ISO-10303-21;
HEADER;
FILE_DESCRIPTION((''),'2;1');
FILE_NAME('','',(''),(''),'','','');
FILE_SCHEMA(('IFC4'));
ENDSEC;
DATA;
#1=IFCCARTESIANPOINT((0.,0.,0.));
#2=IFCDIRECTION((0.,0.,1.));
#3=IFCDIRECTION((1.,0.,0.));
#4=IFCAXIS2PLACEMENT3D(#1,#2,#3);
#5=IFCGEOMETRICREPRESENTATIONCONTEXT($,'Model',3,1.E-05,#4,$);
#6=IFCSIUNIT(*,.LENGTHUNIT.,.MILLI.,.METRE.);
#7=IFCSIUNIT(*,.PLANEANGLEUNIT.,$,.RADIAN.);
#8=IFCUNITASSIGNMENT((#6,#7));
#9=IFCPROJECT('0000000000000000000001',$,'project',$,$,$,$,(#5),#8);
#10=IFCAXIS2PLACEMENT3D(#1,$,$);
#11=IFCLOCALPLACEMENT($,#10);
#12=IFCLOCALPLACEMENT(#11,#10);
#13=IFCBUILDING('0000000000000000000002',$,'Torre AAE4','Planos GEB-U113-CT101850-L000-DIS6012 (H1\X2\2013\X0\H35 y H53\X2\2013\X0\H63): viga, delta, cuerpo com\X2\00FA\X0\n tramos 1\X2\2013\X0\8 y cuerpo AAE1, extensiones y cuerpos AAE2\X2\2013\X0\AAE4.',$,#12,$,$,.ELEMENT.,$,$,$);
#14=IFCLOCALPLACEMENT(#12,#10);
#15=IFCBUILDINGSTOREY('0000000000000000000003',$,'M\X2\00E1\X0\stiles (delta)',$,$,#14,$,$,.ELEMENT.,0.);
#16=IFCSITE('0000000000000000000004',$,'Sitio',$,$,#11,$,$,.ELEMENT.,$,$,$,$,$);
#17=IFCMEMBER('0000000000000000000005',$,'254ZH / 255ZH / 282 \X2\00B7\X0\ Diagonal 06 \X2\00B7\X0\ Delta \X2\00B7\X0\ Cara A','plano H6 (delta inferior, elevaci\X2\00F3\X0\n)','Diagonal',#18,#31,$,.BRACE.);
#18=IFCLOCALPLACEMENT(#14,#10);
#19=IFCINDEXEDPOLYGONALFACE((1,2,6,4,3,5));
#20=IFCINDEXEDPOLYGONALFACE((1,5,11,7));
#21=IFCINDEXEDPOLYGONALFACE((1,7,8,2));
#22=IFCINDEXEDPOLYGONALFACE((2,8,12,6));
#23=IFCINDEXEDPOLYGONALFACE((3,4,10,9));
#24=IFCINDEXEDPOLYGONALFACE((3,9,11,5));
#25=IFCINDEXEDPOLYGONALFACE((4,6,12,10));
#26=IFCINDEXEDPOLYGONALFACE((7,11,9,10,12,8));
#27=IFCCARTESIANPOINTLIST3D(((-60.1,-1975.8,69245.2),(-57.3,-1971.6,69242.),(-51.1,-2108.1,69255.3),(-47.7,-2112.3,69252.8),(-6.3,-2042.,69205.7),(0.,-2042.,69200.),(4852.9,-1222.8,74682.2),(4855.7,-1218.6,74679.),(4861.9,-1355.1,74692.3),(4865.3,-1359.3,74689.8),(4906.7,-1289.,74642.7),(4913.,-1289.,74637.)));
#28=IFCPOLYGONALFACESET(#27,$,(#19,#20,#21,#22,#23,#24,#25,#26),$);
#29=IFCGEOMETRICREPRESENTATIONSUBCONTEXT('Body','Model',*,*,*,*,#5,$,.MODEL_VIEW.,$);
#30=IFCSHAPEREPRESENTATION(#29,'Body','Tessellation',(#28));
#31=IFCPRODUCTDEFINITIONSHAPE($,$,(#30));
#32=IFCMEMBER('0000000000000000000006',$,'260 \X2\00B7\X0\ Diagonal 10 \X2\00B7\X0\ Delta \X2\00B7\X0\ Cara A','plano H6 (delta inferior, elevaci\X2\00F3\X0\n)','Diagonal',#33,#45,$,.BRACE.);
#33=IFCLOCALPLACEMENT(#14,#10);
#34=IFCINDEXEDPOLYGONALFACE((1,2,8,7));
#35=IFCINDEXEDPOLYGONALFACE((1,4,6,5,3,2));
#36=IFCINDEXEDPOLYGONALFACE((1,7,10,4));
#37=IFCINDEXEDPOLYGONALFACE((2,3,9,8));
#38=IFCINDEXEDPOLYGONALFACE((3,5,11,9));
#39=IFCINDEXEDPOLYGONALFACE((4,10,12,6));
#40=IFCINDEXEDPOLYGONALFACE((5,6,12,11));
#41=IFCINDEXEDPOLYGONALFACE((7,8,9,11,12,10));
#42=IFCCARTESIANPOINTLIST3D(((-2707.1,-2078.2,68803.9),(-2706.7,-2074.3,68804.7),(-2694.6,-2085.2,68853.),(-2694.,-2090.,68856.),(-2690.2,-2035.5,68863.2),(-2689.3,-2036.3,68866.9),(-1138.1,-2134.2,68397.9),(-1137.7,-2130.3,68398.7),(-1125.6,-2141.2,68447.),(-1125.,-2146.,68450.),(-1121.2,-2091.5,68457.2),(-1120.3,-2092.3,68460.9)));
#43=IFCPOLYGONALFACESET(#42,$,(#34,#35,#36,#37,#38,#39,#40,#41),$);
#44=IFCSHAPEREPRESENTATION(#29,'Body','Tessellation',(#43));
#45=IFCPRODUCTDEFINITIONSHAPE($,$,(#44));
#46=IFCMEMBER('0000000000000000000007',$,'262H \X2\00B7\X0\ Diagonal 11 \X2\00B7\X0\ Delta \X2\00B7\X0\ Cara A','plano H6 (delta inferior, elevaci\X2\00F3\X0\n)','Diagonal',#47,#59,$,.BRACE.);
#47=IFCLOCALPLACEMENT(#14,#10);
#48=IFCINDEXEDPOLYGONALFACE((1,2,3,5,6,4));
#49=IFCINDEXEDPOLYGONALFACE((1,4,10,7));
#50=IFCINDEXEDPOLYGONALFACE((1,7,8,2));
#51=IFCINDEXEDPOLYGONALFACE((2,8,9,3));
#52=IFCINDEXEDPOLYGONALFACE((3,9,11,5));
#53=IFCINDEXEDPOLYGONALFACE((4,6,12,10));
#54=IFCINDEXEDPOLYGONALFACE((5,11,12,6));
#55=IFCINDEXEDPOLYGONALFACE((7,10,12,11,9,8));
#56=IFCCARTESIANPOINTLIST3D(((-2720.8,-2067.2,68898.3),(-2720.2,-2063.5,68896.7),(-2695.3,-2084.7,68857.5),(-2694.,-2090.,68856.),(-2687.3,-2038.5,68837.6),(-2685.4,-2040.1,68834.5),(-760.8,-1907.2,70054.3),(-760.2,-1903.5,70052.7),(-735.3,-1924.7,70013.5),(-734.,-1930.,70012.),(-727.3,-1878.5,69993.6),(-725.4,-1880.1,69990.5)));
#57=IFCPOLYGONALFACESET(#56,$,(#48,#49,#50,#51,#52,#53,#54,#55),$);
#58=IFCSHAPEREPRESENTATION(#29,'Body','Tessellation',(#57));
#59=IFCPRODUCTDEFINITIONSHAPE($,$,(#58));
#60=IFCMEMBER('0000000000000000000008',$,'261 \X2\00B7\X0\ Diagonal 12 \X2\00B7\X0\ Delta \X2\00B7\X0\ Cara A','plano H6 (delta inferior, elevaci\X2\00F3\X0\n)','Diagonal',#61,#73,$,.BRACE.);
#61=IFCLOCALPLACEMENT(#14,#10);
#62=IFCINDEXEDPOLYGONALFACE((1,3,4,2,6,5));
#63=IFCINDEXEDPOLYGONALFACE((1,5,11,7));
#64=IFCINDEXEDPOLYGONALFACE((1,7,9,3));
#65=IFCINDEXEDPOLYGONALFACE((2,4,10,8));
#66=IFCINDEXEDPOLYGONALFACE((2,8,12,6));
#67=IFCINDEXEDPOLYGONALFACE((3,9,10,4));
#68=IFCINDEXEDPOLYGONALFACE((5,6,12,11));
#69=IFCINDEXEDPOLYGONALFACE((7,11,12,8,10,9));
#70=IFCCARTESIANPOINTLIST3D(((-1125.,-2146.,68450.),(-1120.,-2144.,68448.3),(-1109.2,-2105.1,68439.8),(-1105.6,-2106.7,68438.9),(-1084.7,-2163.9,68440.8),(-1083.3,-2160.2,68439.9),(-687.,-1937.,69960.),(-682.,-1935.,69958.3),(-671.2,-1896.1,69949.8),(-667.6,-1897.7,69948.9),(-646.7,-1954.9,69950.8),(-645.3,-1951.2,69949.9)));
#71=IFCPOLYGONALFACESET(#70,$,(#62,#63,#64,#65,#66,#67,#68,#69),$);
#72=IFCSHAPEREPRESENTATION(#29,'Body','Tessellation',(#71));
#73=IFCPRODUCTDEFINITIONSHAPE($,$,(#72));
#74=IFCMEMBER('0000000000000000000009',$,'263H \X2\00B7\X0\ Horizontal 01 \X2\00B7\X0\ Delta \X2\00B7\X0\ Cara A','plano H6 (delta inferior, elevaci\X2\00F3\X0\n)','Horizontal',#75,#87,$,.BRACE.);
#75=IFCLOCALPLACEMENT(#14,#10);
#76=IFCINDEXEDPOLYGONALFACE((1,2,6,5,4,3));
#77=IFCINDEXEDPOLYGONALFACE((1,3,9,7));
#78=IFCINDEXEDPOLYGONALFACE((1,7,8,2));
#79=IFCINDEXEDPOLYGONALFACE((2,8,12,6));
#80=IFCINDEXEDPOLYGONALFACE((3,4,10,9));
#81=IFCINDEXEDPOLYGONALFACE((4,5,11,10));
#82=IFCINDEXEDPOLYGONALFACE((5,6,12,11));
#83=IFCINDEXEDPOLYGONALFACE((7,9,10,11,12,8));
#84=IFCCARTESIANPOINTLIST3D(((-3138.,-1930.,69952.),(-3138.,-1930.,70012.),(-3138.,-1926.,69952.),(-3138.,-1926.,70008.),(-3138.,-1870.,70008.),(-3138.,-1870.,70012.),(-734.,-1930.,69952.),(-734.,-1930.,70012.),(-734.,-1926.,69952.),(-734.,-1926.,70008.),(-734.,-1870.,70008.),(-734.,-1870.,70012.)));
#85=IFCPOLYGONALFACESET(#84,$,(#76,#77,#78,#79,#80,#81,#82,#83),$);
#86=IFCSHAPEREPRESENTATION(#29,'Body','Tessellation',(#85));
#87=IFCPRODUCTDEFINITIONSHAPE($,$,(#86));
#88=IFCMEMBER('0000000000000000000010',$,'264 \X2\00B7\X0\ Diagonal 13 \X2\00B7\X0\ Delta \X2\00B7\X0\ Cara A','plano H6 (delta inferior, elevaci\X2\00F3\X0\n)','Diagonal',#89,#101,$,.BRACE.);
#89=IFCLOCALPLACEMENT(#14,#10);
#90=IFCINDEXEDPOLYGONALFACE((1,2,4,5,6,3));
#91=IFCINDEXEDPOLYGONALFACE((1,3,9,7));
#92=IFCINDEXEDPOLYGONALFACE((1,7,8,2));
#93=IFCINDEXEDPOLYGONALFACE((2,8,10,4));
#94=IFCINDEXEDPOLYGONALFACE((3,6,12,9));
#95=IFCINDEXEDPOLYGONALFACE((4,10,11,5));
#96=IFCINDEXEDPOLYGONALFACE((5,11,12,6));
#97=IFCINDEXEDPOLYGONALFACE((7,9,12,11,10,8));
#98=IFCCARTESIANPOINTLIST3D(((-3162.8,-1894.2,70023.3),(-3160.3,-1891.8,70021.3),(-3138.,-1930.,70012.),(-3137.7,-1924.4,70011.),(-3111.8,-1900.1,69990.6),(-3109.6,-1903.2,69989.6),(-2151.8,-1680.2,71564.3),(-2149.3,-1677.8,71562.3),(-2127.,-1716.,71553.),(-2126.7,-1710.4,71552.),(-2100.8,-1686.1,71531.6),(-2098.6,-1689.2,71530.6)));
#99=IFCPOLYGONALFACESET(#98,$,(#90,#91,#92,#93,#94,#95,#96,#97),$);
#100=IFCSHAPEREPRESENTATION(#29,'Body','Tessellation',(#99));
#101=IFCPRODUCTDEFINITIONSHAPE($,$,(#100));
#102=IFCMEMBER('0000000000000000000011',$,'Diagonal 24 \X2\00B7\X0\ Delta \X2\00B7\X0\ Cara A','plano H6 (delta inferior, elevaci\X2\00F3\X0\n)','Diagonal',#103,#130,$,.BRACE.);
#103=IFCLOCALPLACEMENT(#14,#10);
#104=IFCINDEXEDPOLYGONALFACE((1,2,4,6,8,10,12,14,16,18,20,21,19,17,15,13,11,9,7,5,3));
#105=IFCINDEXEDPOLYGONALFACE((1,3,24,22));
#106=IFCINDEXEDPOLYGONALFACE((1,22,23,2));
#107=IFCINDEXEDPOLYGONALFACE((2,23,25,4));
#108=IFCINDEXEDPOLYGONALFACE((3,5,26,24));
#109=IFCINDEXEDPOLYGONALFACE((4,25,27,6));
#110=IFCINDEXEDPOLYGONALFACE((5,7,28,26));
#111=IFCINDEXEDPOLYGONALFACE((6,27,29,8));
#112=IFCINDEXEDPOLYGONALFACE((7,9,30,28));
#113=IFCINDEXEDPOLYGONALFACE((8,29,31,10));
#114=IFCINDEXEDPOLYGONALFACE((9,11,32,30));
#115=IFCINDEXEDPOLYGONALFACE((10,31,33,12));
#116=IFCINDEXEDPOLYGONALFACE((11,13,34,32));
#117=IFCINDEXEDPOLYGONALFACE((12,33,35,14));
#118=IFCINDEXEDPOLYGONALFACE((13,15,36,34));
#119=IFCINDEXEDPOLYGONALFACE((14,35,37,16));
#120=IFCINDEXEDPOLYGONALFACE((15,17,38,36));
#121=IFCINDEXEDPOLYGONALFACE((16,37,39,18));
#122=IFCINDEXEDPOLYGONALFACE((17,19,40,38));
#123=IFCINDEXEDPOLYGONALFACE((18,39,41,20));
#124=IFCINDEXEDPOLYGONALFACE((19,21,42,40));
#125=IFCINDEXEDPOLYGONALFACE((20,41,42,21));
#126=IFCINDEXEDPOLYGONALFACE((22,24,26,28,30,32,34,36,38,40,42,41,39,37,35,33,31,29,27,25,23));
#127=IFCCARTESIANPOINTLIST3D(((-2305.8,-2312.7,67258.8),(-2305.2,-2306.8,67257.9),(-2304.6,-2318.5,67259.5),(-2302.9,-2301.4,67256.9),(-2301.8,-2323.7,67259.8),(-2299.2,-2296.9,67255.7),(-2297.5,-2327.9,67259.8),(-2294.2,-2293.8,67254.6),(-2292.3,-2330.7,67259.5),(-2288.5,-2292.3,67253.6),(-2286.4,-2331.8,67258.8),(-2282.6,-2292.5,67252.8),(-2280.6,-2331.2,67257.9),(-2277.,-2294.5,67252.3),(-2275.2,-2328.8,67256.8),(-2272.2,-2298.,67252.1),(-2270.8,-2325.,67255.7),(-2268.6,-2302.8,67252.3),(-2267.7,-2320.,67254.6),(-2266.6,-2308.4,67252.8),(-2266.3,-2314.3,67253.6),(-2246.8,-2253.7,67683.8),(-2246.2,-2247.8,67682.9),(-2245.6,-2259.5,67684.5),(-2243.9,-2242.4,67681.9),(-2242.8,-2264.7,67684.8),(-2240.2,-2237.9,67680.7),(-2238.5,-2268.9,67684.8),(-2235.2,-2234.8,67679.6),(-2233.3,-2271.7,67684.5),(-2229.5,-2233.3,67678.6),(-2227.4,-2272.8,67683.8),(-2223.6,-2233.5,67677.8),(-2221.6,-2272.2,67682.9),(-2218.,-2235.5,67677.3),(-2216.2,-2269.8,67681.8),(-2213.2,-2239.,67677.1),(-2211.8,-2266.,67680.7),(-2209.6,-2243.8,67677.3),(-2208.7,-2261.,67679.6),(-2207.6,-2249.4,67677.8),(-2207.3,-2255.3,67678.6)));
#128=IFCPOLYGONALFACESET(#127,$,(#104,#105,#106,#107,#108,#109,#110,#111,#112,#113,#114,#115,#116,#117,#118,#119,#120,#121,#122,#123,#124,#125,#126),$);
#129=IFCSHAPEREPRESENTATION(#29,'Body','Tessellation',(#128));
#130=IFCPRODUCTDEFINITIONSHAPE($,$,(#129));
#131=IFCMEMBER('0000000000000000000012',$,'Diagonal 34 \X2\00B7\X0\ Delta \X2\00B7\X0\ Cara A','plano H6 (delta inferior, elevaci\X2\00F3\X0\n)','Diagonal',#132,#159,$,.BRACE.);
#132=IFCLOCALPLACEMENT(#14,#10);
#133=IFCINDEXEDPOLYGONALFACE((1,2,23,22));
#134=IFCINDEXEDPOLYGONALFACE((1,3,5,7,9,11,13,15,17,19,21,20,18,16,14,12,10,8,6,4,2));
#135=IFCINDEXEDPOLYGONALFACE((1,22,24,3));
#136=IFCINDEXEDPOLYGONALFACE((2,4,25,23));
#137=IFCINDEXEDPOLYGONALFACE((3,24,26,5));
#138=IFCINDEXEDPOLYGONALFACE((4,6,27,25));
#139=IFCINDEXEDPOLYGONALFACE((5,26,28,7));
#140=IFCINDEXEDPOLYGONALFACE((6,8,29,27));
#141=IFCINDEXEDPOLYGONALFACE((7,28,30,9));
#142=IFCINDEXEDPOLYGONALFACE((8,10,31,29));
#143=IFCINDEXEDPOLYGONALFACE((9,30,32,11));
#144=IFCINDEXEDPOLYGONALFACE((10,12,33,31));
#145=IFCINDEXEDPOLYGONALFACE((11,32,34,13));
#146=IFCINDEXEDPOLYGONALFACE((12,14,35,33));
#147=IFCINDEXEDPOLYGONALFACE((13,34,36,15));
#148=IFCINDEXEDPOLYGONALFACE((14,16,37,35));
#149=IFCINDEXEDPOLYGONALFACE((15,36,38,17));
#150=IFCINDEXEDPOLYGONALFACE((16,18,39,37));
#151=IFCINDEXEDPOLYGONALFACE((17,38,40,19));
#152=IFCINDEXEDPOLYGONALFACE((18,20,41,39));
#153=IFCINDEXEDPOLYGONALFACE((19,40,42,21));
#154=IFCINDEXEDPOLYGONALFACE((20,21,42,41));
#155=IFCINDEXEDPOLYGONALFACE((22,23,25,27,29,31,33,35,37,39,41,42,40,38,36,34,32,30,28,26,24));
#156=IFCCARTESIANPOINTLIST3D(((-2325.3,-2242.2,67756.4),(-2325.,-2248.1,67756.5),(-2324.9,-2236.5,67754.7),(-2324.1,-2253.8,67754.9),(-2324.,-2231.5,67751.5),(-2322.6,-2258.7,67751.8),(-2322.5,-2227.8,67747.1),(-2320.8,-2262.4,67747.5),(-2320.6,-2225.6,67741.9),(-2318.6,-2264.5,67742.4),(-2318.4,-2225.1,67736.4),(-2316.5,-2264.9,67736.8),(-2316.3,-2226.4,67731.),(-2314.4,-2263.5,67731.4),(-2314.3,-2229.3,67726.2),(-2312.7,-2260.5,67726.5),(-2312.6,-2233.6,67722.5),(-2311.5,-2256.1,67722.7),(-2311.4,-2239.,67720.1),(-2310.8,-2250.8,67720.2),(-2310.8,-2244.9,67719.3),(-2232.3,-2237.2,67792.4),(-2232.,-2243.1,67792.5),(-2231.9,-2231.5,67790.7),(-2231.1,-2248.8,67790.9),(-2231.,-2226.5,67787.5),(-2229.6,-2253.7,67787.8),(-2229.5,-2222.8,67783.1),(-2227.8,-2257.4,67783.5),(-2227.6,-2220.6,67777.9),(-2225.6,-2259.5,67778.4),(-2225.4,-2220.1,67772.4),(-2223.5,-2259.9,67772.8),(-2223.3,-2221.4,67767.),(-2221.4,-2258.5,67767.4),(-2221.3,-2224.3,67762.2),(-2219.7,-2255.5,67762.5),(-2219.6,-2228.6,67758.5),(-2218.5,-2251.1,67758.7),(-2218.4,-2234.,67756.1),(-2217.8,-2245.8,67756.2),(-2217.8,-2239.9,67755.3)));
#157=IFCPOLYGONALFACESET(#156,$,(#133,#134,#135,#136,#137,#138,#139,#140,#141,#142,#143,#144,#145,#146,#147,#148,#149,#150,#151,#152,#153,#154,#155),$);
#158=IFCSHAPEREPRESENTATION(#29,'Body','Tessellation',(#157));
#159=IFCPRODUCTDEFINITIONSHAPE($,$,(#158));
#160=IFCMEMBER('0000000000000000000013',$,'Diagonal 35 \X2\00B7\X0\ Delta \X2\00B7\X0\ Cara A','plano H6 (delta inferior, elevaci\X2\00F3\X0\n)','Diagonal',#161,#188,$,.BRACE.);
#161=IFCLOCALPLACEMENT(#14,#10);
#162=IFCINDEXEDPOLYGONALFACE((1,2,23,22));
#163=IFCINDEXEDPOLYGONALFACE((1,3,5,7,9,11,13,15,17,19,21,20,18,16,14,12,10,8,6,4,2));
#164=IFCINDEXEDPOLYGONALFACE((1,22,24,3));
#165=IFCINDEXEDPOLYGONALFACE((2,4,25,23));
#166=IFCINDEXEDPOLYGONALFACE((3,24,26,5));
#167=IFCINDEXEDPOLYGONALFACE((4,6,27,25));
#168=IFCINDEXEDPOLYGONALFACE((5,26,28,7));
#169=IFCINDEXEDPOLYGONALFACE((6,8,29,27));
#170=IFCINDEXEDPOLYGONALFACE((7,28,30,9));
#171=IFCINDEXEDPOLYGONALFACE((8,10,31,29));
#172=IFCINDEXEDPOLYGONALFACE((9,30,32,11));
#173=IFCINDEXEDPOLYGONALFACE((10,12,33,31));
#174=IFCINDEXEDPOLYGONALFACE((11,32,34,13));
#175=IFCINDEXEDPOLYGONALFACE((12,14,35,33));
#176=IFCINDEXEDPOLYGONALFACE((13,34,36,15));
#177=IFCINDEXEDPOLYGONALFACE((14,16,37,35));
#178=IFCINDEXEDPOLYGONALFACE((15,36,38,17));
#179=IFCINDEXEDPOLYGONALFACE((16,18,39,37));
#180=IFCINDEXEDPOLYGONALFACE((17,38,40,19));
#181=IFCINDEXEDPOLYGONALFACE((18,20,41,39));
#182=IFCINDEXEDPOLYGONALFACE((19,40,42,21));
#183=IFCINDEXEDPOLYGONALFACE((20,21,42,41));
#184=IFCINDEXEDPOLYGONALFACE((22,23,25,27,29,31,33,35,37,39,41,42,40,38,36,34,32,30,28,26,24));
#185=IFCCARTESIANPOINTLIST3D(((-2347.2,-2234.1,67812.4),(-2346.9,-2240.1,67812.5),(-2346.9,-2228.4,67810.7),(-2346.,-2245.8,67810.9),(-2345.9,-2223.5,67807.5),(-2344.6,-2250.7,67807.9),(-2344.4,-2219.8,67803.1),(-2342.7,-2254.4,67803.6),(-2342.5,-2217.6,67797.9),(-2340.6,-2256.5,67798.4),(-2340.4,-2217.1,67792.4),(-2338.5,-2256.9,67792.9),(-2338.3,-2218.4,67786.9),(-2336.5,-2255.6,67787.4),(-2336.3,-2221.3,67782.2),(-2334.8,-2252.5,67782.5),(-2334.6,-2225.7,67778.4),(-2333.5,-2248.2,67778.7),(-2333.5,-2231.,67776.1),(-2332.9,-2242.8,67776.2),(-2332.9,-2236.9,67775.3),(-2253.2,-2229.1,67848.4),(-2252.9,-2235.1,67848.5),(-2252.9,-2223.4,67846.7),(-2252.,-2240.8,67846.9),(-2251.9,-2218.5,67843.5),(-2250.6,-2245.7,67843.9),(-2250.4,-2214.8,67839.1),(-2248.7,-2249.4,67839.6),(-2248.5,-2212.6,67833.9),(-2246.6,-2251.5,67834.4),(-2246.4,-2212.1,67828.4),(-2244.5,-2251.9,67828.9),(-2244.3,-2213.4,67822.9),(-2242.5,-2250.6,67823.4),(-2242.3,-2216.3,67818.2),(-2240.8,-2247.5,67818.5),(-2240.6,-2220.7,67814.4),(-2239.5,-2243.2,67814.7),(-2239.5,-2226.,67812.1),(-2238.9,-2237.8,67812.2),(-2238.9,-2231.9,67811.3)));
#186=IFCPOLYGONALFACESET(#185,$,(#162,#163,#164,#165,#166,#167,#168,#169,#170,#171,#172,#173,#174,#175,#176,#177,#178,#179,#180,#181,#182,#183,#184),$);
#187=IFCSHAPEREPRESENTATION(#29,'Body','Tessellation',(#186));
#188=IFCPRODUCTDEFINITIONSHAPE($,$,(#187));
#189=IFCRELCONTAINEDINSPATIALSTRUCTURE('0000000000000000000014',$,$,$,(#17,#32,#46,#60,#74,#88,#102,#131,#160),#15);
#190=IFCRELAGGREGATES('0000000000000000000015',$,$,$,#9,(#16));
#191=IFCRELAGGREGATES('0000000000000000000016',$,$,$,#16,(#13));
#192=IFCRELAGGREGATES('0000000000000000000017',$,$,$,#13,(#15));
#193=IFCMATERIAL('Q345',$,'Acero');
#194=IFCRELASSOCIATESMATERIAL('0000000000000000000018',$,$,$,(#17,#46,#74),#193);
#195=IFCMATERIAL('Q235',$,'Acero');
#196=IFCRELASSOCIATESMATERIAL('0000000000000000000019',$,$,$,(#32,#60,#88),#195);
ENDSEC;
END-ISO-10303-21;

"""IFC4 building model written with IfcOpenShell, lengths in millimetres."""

from ifc_helpers import new_model, si_unit, frame, frame_2d, origin, origin_with_axes, place, context, subcontext, project, spatial, circle, l_section, extrude, material, element, save


model = new_model("IFC4")

# Units and contexts
model_context = context("Model", 3, precision=1e-05, world=origin_with_axes())
body_context = subcontext(model_context, "Body", "Model", "MODEL_VIEW")
ifc_project = project(units=[si_unit("LENGTHUNIT", "METRE", prefix="MILLI"), si_unit("PLANEANGLEUNIT", "RADIAN")], contexts=[model_context])

# Site, building, storey
site_placement = place(None, origin())
site = spatial("IfcSite", under=ifc_project, at=site_placement, Name="Sitio", CompositionType="ELEMENT")
building_placement = place(site_placement, origin())
building = spatial("IfcBuilding", under=site, at=building_placement, Name="Torre AAE4", Description="Planos GEB-U113-CT101850-L000-DIS6012 (H1–H35 y H53–H63): viga, delta, cuerpo común tramos 1–8 y cuerpo AAE1, extensiones y cuerpos AAE2–AAE4.", CompositionType="ELEMENT")
storey_placement = place(building_placement, origin())
storey = spatial("IfcBuildingStorey", under=building, at=storey_placement, Name="Mástiles (delta)", CompositionType="ELEMENT", Elevation=0.0)

# Members
ifc_material_1 = material(Name="Q345", Category="Acero")
member_1_placement = place(storey_placement, frame((0.0, -2042.0, 69200.0), z_axis=(0.666937, 0.102219, 0.738069), x_axis=(-0.572774, 0.703887, 0.420087)))
element("IfcMember", 1, at=member_1_placement, inside=storey, material=ifc_material_1, Name="254ZH / 255ZH / 282 · Diagonal 06 · Delta · Cara A", Description="plano H6 (delta inferior, elevación)", ObjectType="Diagonal", PredefinedType="BRACE", context=body_context, shape_type="SweptSolid", body=[
    extrude(l_section(Depth=100.0, Width=100.0, Thickness=6.0, at=frame_2d((50.0, 50.0))), None, (0.0, 0.0, 1.0), 7366.5),
])
ifc_material_2 = material(Name="Q235", Category="Acero")
member_2_placement = place(storey_placement, frame((-1125.0, -2146.0, 68450.0), z_axis=(-0.967536, 0.034533, 0.250363), x_axis=(0.086334, 0.976191, 0.198993)))
element("IfcMember", 2, at=member_2_placement, inside=storey, material=ifc_material_2, Name="260 · Diagonal 10 · Delta · Cara A", Description="plano H6 (delta inferior, elevación)", ObjectType="Diagonal", PredefinedType="BRACE", context=body_context, shape_type="SweptSolid", body=[
    extrude(l_section(Depth=55.0, Width=55.0, Thickness=4.0, at=frame_2d((27.5, 27.5))), None, (0.0, 0.0, 1.0), 1621.6),
])
member_3_placement = place(storey_placement, frame((-2694.0, -2090.0, 68856.0), z_axis=(0.859225, 0.070141, 0.506767), x_axis=(0.156582, 0.906966, -0.391017)))
element("IfcMember", 3, at=member_3_placement, inside=storey, material=ifc_material_1, Name="262H · Diagonal 11 · Delta · Cara A", Description="plano H6 (delta inferior, elevación)", ObjectType="Diagonal", PredefinedType="BRACE", context=body_context, shape_type="SweptSolid", body=[
    extrude(l_section(Depth=55.0, Width=55.0, Thickness=4.0, at=frame_2d((27.5, 27.5))), None, (0.0, 0.0, 1.0), 2281.1),
])
member_4_placement = place(storey_placement, frame((-687.0, -1937.0, 69960.0), z_axis=(-0.276154, -0.131772, -0.952037), x_axis=(0.351062, 0.908283, -0.227547)))
element("IfcMember", 4, at=member_4_placement, inside=storey, material=ifc_material_2, Name="261 · Diagonal 12 · Delta · Cara A", Description="plano H6 (delta inferior, elevación)", ObjectType="Diagonal", PredefinedType="BRACE", context=body_context, shape_type="SweptSolid", body=[
    extrude(l_section(Depth=45.0, Width=45.0, Thickness=4.0, at=frame_2d((22.5, 22.5))), None, (0.0, 0.0, 1.0), 1586.1),
])
member_5_placement = place(storey_placement, frame((-734.0, -1930.0, 70012.0), z_axis=(-1.0, 0.0, 0.0), x_axis=(0.0, 1.0, 0.0)))
element("IfcMember", 5, at=member_5_placement, inside=storey, material=ifc_material_1, Name="263H · Horizontal 01 · Delta · Cara A", Description="plano H6 (delta inferior, elevación)", ObjectType="Horizontal", PredefinedType="BRACE", context=body_context, shape_type="SweptSolid", body=[
    extrude(l_section(Depth=60.0, Width=60.0, Thickness=4.0, at=frame_2d((30.0, 30.0))), None, (0.0, 0.0, 1.0), 2404.0),
])
member_6_placement = place(storey_placement, frame((-3138.0, -1930.0, 70012.0), z_axis=(0.544889, 0.115338, 0.830538), x_axis=(0.631982, 0.594484, -0.49718)))
element("IfcMember", 6, at=member_6_placement, inside=storey, material=ifc_material_2, Name="264 · Diagonal 13 · Delta · Cara A", Description="plano H6 (delta inferior, elevación)", ObjectType="Diagonal", PredefinedType="BRACE", context=body_context, shape_type="SweptSolid", body=[
    extrude(l_section(Depth=45.0, Width=45.0, Thickness=4.0, at=frame_2d((22.5, 22.5))), None, (0.0, 0.0, 1.0), 1855.4),
])
member_7_placement = place(storey_placement, frame((-2227.0, -2253.0, 67681.0), z_axis=(-0.136223, -0.136223, -0.981268), x_axis=(0.689722, 0.697977, -0.192645)))
element("IfcMember", 7, at=member_7_placement, inside=storey, Name="Diagonal 24 · Delta · Cara A", Description="plano H6 (delta inferior, elevación)", ObjectType="Diagonal", PredefinedType="BRACE", context=body_context, shape_type="SweptSolid", body=[
    extrude(circle(Radius=20.0), None, (0.0, 0.0, 1.0), 433.1),
])
member_8_placement = place(storey_placement, frame((-2318.0, -2245.0, 67738.0), z_axis=(0.931398, 0.050075, 0.360541), x_axis=(0.085914, 0.932266, -0.351425)))
element("IfcMember", 8, at=member_8_placement, inside=storey, Name="Diagonal 34 · Delta · Cara A", Description="plano H6 (delta inferior, elevación)", ObjectType="Diagonal", PredefinedType="BRACE", context=body_context, shape_type="SweptSolid", body=[
    extrude(circle(Radius=20.0), None, (0.0, 0.0, 1.0), 99.8),
])
member_9_placement = place(storey_placement, frame((-2340.0, -2237.0, 67794.0), z_axis=(0.932707, 0.049612, 0.357207), x_axis=(0.085516, 0.931817, -0.35271)))
element("IfcMember", 9, at=member_9_placement, inside=storey, Name="Diagonal 35 · Delta · Cara A", Description="plano H6 (delta inferior, elevación)", ObjectType="Diagonal", PredefinedType="BRACE", context=body_context, shape_type="SweptSolid", body=[
    extrude(circle(Radius=20.0), None, (0.0, 0.0, 1.0), 100.8),
])

save(model, "model.ifc")
